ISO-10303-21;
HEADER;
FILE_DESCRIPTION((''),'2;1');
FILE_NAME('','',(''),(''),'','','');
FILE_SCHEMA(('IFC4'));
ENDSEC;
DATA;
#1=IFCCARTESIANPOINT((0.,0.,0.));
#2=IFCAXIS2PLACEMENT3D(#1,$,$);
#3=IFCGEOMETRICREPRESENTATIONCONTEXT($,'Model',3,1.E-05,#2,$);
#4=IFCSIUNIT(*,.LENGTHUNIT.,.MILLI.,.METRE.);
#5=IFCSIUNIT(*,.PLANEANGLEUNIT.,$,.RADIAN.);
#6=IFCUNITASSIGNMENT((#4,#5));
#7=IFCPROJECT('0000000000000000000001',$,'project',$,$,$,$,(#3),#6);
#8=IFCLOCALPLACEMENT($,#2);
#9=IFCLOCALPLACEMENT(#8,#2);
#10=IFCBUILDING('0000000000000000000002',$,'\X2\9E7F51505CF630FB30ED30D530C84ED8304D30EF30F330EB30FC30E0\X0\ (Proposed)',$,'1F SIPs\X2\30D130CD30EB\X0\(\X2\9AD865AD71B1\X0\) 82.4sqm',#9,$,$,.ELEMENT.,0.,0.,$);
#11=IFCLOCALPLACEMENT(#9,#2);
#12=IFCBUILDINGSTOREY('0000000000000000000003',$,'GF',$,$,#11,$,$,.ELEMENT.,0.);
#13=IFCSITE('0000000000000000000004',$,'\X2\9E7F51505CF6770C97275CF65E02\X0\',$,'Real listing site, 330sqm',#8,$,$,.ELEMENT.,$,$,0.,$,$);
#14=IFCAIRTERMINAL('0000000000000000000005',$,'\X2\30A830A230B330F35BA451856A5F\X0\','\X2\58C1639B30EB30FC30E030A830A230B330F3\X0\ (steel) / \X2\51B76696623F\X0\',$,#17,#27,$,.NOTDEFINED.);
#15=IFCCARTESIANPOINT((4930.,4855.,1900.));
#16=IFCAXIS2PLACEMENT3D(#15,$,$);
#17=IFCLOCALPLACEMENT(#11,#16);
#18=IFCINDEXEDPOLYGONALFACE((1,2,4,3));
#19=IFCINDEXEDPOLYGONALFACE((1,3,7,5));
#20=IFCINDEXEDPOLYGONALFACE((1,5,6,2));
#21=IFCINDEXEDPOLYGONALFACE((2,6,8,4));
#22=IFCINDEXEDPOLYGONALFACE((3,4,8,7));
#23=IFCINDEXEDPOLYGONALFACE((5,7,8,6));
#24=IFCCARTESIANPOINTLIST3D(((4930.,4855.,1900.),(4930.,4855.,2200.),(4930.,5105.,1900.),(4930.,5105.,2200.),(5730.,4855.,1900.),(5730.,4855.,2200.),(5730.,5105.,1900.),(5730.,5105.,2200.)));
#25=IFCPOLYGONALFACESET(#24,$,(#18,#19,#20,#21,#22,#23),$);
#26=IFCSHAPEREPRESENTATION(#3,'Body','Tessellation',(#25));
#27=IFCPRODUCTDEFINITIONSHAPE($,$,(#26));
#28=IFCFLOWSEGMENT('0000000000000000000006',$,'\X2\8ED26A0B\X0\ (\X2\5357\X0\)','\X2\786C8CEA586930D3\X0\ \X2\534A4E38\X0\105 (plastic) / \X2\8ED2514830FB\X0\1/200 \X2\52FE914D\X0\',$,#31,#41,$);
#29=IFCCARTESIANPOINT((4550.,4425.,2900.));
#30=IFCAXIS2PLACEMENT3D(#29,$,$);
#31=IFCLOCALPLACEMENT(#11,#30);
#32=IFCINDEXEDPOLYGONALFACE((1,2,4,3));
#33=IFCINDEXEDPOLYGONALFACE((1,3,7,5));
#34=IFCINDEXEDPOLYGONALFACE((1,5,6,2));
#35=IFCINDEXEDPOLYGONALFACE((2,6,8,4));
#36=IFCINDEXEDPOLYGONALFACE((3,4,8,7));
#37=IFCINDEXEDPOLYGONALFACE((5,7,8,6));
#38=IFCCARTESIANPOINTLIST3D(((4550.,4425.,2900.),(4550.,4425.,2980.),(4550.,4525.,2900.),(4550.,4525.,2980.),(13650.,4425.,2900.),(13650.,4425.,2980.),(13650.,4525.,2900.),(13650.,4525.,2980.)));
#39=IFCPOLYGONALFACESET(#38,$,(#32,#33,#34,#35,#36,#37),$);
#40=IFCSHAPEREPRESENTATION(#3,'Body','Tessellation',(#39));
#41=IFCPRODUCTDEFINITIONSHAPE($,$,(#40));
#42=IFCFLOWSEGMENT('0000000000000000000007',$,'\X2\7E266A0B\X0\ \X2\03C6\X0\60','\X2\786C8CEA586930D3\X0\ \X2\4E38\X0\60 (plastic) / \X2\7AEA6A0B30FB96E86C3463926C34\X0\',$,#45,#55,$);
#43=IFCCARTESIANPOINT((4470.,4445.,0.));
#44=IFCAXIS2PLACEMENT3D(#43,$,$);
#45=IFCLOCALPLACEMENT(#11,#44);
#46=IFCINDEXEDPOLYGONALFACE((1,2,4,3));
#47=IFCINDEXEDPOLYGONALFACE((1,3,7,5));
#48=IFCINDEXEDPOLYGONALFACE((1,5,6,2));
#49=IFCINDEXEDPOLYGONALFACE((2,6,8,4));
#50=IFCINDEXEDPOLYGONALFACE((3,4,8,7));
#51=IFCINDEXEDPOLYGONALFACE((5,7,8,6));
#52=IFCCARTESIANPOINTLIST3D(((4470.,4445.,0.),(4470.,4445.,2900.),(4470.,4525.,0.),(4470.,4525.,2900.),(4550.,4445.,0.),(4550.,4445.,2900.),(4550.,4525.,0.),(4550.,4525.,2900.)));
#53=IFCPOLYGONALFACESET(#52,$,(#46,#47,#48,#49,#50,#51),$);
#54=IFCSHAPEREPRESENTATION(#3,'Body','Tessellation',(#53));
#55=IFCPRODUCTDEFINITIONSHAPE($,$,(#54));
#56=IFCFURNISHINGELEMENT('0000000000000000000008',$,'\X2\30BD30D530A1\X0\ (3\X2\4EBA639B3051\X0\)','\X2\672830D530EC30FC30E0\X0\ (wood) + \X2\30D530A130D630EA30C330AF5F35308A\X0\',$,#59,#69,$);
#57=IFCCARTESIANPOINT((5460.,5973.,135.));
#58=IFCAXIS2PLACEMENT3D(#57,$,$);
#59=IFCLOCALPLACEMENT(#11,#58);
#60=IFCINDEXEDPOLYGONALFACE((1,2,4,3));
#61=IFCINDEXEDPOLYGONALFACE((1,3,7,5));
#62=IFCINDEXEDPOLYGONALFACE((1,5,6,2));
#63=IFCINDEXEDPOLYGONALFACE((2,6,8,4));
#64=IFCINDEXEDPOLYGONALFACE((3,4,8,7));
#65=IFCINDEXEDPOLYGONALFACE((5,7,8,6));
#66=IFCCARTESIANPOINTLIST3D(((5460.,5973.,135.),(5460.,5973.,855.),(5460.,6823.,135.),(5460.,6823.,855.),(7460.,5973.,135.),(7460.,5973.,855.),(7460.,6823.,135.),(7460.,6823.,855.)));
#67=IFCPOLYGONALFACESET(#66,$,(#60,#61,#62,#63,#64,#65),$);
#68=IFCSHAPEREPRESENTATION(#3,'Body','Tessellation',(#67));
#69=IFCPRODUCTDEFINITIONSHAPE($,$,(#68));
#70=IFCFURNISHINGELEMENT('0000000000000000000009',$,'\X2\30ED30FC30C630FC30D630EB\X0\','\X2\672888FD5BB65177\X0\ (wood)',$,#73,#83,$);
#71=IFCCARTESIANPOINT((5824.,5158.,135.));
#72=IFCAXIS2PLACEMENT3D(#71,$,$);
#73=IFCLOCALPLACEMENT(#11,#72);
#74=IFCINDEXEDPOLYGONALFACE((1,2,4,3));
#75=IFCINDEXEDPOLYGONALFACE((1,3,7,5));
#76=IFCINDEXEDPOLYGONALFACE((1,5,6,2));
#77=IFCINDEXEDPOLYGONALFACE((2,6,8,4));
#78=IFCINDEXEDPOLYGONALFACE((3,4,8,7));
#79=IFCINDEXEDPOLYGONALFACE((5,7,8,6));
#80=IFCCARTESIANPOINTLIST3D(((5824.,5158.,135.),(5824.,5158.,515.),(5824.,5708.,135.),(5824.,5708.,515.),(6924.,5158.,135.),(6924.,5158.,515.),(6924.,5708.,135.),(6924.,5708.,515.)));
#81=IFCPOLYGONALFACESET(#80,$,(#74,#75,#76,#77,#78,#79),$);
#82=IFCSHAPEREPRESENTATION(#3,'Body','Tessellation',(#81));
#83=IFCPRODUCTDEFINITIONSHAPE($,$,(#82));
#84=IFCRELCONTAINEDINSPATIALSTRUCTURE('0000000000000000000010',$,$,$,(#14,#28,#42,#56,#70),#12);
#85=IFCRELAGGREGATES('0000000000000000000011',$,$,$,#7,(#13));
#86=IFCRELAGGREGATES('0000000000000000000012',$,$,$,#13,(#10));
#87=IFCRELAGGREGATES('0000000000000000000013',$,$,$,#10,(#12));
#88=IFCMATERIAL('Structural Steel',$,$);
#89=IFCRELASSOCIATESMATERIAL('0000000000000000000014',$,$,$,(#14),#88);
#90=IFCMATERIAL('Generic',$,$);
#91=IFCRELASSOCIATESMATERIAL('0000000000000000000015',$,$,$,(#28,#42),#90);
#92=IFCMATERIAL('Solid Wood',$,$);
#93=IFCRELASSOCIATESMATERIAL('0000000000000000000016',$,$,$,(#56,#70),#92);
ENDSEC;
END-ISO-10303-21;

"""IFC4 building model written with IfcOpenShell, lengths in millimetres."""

from ifc_helpers import new_model, si_unit, frame, frame_2d, origin, place, context, project, spatial, rectangle, extrude, material, element, save


model = new_model("IFC4")

# Units and contexts
model_context = context("Model", 3, precision=1e-05, world=origin())
ifc_project = project(units=[si_unit("LENGTHUNIT", "METRE", prefix="MILLI"), si_unit("PLANEANGLEUNIT", "RADIAN")], contexts=[model_context])

# Site, building, storey
site_placement = place(None, origin())
site = spatial("IfcSite", under=ifc_project, at=site_placement, Name="鹿児島県霧島市", ObjectType="Real listing site, 330sqm", CompositionType="ELEMENT", RefElevation=0.0)
building_placement = place(site_placement, origin())
building = spatial("IfcBuilding", under=site, at=building_placement, Name="鹿児島・ロフト付きワンルーム (Proposed)", ObjectType="1F SIPsパネル(高断熱) 82.4sqm", CompositionType="ELEMENT", ElevationOfRefHeight=0.0, ElevationOfTerrain=0.0)
storey_placement = place(building_placement, origin())
storey = spatial("IfcBuildingStorey", under=building, at=storey_placement, Name="GF", CompositionType="ELEMENT", Elevation=0.0)

# Shared definitions
ifc_material_1 = material(Name="Solid Wood")

# Shared definitions
ifc_material_2 = material(Name="Structural Steel")

# Shared definitions
ifc_material_3 = material(Name="Generic")

# Air terminal
air_terminal_placement = place(storey_placement, frame((4930.0, 4855.0, 1900.0)))
element("IfcAirTerminal", 1, at=air_terminal_placement, inside=storey, material=ifc_material_2, Name="エアコン室内機", Description="壁掛ルームエアコン (steel) / 冷暖房", PredefinedType="NOTDEFINED", context=model_context, shape_type="SweptSolid", body=[
    extrude(rectangle(XDim=800.0, YDim=250.0, at=frame_2d((400.0, 125.0))), frame((4930.0, 4855.0, 1900.0)), (0.0, 0.0, 1.0), 300.0),
])

# Flow segments
flow_segment_1_placement = place(storey_placement, frame((4550.0, 4425.0, 2900.0)))
element("IfcFlowSegment", 2, at=flow_segment_1_placement, inside=storey, material=ifc_material_3, Name="軒樋 (南)", Description="硬質塩ビ 半丸105 (plastic) / 軒先・1/200 勾配", context=model_context, shape_type="SweptSolid", body=[
    extrude(rectangle(XDim=9100.0, YDim=100.0, at=frame_2d((4550.0, 50.0))), frame((4550.0, 4425.0, 2900.0)), (0.0, 0.0, 1.0), 80.0),
])
flow_segment_2_placement = place(storey_placement, frame((4470.0, 4445.0, 0.0)))
element("IfcFlowSegment", 3, at=flow_segment_2_placement, inside=storey, material=ifc_material_3, Name="縦樋 φ60", Description="硬質塩ビ 丸60 (plastic) / 竪樋・雨水排水", context=model_context, shape_type="SweptSolid", body=[
    extrude(rectangle(XDim=80.0, YDim=80.0, at=frame_2d((40.0, 40.0))), frame((4470.0, 4445.0, 0.0)), (0.0, 0.0, 1.0), 2900.0),
])

# Furnishing elements
furnishing_1_placement = place(storey_placement, frame((5460.0, 5973.0, 135.0)))
element("IfcFurnishingElement", 4, at=furnishing_1_placement, inside=storey, material=ifc_material_1, Name="ソファ (3人掛け)", Description="木フレーム (wood) + ファブリック張り", context=model_context, shape_type="SweptSolid", body=[
    extrude(rectangle(XDim=2000.0, YDim=850.0, at=frame_2d((1000.0, 425.0))), frame((5460.0, 5973.0, 135.0)), (0.0, 0.0, 1.0), 720.0),
])
furnishing_2_placement = place(storey_placement, frame((5824.0, 5158.0, 135.0)))
element("IfcFurnishingElement", 5, at=furnishing_2_placement, inside=storey, material=ifc_material_1, Name="ローテーブル", Description="木製家具 (wood)", context=model_context, shape_type="SweptSolid", body=[
    extrude(rectangle(XDim=1100.0, YDim=550.0, at=frame_2d((550.0, 275.0))), frame((5824.0, 5158.0, 135.0)), (0.0, 0.0, 1.0), 380.0),
])

save(model, "model.ifc")
